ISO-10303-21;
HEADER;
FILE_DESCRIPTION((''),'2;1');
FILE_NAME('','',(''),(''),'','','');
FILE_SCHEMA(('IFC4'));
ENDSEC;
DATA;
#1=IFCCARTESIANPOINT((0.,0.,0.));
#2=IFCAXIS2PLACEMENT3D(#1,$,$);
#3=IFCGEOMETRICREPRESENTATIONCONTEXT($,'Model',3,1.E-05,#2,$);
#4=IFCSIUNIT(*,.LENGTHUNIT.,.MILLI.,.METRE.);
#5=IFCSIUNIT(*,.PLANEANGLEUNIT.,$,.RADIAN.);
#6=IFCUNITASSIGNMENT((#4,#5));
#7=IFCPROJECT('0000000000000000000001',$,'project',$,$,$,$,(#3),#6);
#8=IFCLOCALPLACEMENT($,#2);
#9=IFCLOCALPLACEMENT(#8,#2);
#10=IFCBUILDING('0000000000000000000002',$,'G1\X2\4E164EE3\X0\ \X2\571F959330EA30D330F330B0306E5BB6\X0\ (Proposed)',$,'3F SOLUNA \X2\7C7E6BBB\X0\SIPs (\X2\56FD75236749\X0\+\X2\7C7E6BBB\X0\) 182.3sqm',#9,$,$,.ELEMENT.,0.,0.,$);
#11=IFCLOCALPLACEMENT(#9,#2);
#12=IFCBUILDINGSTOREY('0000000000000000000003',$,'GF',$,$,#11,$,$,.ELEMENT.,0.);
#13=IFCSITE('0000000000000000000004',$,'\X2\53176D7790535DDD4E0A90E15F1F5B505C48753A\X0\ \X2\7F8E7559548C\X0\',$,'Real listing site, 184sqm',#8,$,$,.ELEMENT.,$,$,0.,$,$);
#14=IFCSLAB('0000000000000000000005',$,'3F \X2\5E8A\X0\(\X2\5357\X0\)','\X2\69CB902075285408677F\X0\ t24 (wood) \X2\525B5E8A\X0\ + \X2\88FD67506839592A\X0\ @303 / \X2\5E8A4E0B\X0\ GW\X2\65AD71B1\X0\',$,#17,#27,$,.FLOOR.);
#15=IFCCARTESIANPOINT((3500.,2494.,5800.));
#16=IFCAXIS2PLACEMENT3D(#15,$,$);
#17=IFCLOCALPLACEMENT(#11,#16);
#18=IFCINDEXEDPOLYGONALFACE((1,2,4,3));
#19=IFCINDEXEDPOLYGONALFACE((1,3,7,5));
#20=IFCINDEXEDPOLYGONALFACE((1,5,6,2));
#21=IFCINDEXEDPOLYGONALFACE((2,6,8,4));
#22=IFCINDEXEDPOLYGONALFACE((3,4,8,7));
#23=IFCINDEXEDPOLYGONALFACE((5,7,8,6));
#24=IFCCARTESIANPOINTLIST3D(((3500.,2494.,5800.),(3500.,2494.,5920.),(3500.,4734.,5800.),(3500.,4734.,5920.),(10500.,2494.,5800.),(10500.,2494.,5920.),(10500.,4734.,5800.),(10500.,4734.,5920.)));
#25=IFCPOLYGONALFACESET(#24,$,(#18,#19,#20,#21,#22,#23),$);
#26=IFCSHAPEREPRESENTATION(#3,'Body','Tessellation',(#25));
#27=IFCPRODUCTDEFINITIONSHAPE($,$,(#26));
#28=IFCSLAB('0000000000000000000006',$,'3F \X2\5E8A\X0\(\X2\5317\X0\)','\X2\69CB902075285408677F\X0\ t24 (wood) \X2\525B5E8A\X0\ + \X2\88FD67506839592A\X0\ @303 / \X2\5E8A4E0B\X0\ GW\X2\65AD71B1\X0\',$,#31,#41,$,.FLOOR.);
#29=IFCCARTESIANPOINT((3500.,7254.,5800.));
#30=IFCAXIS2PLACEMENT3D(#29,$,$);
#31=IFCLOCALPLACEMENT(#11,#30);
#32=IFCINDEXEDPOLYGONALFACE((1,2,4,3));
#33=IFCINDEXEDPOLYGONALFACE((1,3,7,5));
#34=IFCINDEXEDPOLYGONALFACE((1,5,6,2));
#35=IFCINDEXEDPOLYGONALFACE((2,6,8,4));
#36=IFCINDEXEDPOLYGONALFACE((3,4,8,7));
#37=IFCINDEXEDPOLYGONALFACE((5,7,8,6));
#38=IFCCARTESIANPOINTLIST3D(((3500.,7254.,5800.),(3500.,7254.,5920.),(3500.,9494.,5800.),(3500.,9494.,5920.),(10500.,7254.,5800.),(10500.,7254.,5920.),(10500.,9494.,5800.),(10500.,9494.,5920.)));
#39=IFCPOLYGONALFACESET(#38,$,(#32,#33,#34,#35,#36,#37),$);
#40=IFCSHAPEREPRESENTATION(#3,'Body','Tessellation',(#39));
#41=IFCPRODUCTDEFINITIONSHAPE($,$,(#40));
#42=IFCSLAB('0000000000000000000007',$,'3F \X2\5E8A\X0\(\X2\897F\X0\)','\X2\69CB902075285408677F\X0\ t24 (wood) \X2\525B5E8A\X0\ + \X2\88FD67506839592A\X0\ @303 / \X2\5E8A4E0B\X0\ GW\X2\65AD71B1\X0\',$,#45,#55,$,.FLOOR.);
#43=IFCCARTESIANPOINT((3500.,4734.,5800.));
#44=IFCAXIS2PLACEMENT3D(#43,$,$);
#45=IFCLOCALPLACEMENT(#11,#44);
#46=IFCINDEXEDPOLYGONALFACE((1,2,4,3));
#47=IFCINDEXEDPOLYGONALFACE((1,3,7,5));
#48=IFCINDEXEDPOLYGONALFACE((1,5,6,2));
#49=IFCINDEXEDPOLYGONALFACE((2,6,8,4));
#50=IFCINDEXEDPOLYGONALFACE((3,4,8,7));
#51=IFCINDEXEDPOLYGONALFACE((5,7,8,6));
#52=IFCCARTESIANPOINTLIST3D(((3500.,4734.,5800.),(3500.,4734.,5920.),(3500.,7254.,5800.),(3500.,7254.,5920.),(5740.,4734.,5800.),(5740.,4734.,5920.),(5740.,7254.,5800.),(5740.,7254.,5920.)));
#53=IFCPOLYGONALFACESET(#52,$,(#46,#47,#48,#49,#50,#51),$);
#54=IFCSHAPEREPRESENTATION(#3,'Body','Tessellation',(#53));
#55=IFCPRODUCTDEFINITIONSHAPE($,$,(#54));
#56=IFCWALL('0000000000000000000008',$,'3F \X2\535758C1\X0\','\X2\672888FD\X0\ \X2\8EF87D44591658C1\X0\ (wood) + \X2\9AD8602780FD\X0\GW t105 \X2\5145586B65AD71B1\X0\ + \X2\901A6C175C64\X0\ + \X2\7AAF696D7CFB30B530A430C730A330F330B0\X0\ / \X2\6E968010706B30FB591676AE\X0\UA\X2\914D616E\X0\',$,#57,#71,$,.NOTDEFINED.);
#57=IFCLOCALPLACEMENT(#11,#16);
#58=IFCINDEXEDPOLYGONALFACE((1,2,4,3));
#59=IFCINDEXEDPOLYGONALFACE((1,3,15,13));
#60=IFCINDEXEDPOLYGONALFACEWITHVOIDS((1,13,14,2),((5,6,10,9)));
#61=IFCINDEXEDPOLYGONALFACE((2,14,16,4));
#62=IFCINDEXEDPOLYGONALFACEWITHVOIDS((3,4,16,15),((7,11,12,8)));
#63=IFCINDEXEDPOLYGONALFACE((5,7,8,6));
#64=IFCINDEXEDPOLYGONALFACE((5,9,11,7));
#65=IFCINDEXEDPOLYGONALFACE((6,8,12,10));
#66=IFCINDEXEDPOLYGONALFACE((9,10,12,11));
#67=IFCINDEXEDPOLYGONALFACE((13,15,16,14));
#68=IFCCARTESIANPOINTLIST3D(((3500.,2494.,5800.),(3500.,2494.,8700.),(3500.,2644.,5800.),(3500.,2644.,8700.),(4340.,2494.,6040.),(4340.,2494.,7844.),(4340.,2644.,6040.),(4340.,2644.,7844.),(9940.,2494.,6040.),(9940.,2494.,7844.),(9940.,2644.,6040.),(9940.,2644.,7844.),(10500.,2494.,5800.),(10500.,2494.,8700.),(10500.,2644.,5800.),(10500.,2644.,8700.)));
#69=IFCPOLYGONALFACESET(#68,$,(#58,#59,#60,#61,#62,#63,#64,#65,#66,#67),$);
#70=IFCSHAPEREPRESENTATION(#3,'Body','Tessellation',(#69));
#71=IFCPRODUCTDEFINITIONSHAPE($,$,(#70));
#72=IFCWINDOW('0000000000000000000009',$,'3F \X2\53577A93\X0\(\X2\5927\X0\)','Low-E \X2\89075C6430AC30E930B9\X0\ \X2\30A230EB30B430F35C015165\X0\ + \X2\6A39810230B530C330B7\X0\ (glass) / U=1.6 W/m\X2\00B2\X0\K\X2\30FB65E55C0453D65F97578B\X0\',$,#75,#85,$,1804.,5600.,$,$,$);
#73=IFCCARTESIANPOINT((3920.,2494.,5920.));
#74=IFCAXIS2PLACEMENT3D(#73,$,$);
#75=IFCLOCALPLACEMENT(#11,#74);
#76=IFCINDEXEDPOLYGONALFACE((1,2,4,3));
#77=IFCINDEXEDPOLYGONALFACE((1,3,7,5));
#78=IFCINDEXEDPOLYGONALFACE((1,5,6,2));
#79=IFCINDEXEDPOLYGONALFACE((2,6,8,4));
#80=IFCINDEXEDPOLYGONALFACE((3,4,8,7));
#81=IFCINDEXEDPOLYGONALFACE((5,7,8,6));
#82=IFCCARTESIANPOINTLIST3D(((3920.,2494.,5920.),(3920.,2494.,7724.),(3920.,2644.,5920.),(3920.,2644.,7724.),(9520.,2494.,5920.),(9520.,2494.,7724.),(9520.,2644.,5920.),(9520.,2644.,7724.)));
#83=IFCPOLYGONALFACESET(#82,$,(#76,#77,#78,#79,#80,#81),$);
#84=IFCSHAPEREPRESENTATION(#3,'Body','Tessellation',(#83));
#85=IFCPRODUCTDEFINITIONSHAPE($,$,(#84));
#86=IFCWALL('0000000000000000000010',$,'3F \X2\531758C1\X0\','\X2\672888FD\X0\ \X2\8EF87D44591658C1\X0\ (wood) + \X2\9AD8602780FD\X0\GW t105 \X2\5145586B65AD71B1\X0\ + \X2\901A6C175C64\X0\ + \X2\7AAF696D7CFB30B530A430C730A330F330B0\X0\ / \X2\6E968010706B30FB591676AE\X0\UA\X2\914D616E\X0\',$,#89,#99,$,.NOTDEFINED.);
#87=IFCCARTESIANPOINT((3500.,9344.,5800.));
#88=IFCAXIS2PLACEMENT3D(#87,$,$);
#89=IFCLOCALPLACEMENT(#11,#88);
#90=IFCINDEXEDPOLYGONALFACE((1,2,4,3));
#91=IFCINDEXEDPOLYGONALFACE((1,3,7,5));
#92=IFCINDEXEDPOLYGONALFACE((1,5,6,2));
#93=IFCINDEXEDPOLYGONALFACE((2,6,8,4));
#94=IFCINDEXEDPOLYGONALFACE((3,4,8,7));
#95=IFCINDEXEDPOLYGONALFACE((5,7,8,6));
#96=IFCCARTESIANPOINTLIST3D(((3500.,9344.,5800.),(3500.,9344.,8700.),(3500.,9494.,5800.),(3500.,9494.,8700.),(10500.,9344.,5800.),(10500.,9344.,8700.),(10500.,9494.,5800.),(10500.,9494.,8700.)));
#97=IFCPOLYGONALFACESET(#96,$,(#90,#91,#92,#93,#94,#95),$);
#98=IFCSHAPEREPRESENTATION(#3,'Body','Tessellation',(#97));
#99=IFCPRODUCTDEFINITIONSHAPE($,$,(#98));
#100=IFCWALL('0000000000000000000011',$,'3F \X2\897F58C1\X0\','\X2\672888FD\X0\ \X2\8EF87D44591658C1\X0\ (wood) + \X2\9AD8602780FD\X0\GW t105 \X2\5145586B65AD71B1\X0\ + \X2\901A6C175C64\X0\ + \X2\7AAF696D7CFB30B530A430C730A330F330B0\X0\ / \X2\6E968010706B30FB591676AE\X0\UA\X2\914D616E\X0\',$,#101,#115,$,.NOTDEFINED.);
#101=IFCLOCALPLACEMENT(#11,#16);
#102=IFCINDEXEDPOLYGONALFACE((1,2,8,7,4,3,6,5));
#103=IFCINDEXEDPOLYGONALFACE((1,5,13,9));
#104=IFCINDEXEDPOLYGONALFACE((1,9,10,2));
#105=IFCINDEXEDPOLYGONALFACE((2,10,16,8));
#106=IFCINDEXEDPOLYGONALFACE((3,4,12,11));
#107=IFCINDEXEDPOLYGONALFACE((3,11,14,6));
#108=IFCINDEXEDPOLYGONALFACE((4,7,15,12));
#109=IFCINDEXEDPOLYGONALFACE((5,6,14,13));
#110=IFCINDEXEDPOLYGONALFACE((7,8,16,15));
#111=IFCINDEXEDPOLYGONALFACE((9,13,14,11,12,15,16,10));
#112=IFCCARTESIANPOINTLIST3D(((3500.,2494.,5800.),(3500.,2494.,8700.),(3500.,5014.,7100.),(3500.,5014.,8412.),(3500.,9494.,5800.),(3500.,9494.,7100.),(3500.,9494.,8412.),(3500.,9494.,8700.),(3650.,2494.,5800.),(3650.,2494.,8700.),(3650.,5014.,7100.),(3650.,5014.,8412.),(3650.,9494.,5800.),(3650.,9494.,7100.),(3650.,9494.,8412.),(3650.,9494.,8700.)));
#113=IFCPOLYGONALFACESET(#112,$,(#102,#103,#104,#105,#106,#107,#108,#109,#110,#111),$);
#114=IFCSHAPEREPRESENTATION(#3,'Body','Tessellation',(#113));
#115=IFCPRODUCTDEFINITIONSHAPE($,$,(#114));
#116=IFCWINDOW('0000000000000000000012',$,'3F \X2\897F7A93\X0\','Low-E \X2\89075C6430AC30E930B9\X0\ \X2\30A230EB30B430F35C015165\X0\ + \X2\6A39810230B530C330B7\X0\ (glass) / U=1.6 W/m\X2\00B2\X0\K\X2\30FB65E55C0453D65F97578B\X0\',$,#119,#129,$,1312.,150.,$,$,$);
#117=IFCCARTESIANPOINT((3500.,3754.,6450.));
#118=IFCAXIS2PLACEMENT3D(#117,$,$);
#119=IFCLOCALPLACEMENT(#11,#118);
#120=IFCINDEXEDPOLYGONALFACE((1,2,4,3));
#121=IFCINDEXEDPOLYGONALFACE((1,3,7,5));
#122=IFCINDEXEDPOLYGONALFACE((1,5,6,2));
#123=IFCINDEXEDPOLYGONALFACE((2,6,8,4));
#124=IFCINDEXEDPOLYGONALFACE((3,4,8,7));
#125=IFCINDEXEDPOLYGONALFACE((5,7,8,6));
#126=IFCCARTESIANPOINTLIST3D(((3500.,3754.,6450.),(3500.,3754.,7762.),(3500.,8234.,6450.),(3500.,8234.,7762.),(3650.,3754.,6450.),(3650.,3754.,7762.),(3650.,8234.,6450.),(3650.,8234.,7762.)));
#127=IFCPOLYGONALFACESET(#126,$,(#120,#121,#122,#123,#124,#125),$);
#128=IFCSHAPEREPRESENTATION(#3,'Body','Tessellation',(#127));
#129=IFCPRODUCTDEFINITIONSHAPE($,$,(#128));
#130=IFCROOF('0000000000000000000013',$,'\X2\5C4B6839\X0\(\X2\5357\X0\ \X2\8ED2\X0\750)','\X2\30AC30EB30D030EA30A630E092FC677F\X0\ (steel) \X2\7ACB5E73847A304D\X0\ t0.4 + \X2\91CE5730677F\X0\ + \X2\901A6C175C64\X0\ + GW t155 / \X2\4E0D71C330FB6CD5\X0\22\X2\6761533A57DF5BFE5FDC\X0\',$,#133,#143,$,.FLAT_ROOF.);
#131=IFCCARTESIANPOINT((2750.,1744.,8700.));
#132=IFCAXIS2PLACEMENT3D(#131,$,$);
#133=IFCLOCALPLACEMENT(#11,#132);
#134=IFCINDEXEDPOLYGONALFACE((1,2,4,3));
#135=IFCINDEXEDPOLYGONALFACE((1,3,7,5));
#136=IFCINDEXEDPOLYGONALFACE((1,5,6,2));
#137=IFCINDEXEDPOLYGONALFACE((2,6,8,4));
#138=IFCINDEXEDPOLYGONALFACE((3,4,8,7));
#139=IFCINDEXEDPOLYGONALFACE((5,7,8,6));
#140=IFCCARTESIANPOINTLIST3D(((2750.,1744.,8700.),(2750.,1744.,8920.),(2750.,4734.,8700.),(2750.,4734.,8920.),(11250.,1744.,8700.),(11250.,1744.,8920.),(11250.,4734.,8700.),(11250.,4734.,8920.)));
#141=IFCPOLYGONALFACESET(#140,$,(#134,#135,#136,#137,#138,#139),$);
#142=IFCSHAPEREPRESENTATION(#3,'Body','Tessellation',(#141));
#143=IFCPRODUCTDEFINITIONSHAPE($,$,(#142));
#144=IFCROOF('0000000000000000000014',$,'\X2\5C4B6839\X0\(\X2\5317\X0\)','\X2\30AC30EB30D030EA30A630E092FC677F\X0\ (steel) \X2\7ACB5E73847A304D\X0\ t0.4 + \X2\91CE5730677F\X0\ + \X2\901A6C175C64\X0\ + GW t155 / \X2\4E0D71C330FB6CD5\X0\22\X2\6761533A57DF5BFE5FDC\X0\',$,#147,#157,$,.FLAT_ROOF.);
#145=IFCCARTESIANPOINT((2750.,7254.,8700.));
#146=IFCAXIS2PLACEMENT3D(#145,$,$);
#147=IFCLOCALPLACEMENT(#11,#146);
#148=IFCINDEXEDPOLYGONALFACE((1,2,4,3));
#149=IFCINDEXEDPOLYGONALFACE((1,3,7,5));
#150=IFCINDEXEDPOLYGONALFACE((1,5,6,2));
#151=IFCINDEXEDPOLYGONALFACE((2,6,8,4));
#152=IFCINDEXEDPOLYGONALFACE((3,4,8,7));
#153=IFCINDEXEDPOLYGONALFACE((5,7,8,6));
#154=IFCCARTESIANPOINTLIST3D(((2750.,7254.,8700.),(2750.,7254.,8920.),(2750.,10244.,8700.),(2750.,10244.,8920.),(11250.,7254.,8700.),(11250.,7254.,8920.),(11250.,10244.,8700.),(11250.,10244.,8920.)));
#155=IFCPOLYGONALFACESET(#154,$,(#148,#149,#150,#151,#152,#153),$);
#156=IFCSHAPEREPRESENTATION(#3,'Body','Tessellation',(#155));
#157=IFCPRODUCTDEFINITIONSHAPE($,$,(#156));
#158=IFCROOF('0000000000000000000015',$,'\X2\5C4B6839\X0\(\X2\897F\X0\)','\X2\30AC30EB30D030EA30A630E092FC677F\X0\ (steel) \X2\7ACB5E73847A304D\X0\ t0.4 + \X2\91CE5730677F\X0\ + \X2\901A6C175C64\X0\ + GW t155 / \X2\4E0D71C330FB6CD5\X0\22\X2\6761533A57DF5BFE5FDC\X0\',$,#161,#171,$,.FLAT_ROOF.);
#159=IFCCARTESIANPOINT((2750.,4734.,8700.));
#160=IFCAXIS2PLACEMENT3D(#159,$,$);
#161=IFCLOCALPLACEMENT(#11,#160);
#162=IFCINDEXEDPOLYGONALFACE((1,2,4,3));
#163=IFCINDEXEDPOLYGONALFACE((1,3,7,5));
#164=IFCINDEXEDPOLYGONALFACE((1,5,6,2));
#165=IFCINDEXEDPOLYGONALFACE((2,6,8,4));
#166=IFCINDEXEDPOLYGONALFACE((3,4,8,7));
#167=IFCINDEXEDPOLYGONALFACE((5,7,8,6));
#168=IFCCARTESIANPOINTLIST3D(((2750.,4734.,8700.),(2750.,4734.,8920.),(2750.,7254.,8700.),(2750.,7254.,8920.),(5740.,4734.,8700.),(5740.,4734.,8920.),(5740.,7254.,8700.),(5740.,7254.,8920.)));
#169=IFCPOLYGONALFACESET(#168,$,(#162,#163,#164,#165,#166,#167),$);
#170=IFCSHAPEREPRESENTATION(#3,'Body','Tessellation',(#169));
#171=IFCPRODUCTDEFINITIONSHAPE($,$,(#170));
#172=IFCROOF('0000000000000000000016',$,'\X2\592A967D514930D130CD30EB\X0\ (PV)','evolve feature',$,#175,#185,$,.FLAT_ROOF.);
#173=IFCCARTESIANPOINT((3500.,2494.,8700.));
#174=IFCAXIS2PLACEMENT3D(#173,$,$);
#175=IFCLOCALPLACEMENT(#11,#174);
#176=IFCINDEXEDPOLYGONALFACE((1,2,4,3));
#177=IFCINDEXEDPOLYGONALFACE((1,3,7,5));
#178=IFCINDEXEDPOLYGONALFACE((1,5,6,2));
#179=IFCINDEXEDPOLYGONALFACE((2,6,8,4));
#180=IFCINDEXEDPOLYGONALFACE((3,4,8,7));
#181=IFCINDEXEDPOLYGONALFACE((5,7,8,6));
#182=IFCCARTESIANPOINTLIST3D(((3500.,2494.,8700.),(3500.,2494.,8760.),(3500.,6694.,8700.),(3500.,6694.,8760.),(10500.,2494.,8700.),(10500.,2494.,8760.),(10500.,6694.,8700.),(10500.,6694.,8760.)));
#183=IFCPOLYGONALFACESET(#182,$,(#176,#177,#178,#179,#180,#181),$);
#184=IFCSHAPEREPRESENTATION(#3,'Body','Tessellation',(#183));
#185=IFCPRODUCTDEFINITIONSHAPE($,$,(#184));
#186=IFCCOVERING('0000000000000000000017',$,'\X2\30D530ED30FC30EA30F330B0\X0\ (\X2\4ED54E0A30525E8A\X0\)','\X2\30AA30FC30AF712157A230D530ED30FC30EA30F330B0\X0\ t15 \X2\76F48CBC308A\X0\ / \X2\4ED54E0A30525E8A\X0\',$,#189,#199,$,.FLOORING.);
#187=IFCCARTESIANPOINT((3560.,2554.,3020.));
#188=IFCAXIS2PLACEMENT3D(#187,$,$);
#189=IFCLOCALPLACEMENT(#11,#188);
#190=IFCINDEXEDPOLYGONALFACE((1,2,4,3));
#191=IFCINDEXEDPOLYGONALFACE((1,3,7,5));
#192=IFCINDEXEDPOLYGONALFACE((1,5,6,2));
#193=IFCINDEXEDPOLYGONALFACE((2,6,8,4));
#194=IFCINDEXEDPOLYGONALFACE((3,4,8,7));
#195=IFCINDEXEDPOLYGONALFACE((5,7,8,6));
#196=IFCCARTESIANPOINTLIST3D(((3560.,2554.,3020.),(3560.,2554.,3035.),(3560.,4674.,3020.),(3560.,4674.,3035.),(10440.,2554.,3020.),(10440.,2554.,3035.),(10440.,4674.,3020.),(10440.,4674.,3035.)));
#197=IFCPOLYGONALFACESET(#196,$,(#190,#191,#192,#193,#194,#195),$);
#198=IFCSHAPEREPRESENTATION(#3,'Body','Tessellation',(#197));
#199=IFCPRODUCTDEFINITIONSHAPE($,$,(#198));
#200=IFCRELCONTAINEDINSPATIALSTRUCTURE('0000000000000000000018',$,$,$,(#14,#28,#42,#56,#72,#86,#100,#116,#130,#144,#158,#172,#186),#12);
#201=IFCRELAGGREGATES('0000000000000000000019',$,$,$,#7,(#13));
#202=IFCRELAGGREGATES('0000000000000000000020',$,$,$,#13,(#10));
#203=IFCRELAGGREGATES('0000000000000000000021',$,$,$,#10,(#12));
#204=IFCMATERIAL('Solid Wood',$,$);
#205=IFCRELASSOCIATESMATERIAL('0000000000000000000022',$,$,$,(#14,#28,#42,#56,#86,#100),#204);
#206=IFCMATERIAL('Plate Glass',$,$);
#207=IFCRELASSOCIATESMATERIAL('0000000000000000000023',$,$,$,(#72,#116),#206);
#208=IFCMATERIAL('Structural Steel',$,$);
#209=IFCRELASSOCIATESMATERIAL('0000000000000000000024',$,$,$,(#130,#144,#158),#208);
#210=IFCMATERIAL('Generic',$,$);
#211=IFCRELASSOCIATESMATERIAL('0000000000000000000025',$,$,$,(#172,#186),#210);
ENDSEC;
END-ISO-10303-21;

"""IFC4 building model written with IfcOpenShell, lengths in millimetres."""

from ifc_helpers import new_model, si_unit, frame, frame_2d, origin, place, context, project, spatial, rectangle, extrude, material, element, fill, save


model = new_model("IFC4")

# Units and contexts
model_context = context("Model", 3, precision=1e-05, world=origin())
ifc_project = project(units=[si_unit("LENGTHUNIT", "METRE", prefix="MILLI"), si_unit("PLANEANGLEUNIT", "RADIAN")], contexts=[model_context])

# Site, building, storey
site_placement = place(None, origin())
site = spatial("IfcSite", under=ifc_project, at=site_placement, Name="北海道川上郡弟子屈町 美留和", ObjectType="Real listing site, 184sqm", CompositionType="ELEMENT", RefElevation=0.0)
building_placement = place(site_placement, origin())
building = spatial("IfcBuilding", under=site, at=building_placement, Name="G1世代 土間リビングの家 (Proposed)", ObjectType="3F SOLUNA 籾殻SIPs (国産杉+籾殻) 182.3sqm", CompositionType="ELEMENT", ElevationOfRefHeight=0.0, ElevationOfTerrain=0.0)
storey_placement = place(building_placement, origin())
storey = spatial("IfcBuildingStorey", under=building, at=storey_placement, Name="GF", CompositionType="ELEMENT", Elevation=0.0)

# Slabs
ifc_material_1 = material(Name="Solid Wood")
slab_1_placement = place(storey_placement, frame((3500.0, 2494.0, 5800.0)))
element("IfcSlab", 1, at=slab_1_placement, inside=storey, material=ifc_material_1, Name="3F 床(南)", Description="構造用合板 t24 (wood) 剛床 + 製材根太 @303 / 床下 GW断熱", PredefinedType="FLOOR", context=model_context, shape_type="SweptSolid", body=[
    extrude(rectangle(XDim=7000.0, YDim=2240.0, at=frame_2d((3500.0, 1120.0))), frame((3500.0, 2494.0, 5800.0)), (0.0, 0.0, 1.0), 120.0),
])
slab_2_placement = place(storey_placement, frame((3500.0, 7254.0, 5800.0)))
element("IfcSlab", 2, at=slab_2_placement, inside=storey, material=ifc_material_1, Name="3F 床(北)", Description="構造用合板 t24 (wood) 剛床 + 製材根太 @303 / 床下 GW断熱", PredefinedType="FLOOR", context=model_context, shape_type="SweptSolid", body=[
    extrude(rectangle(XDim=7000.0, YDim=2240.0, at=frame_2d((3500.0, 1120.0))), frame((3500.0, 7254.0, 5800.0)), (0.0, 0.0, 1.0), 120.0),
])
slab_3_placement = place(storey_placement, frame((3500.0, 4734.0, 5800.0)))
element("IfcSlab", 3, at=slab_3_placement, inside=storey, material=ifc_material_1, Name="3F 床(西)", Description="構造用合板 t24 (wood) 剛床 + 製材根太 @303 / 床下 GW断熱", PredefinedType="FLOOR", context=model_context, shape_type="SweptSolid", body=[
    extrude(rectangle(XDim=2240.0, YDim=2520.0, at=frame_2d((1120.0, 1260.0))), frame((3500.0, 4734.0, 5800.0)), (0.0, 0.0, 1.0), 120.0),
])

# Wall, opening, window
wall_1_placement = place(storey_placement, frame((3500.0, 2494.0, 5800.0)))
wall_1 = element("IfcWall", 4, at=wall_1_placement, inside=storey, material=ifc_material_1, Name="3F 南壁", Description="木製 軸組外壁 (wood) + 高性能GW t105 充填断熱 + 通気層 + 窯業系サイディング / 準耐火・外皮UA配慮", PredefinedType="NOTDEFINED", context=model_context, shape_type="SweptSolid", body=[
    extrude(rectangle(XDim=7000.0, YDim=150.0, at=frame_2d((3500.0, 75.0))), frame((3500.0, 2494.0, 5800.0)), (0.0, 0.0, 1.0), 2900.0),
])
opening_1_placement = place(storey_placement, frame((3920.0, 2494.0, 5920.0)))
opening_1 = element("IfcOpeningElement", 5, at=opening_1_placement, cuts=wall_1, PredefinedType="NOTDEFINED", context=model_context, shape_type="SweptSolid", body=[
    extrude(rectangle(XDim=5600.0, YDim=150.0, at=frame_2d((2800.0, 75.0))), frame((3920.0, 2494.0, 5920.0)), (0.0, 0.0, 1.0), 1804.0),
])
ifc_material_2 = material(Name="Plate Glass")
window_1_placement = place(storey_placement, frame((3920.0, 2494.0, 5920.0)))
window_1 = element("IfcWindow", 6, at=window_1_placement, inside=storey, material=ifc_material_2, Name="3F 南窓(大)", Description="Low-E 複層ガラス アルゴン封入 + 樹脂サッシ (glass) / U=1.6 W/m²K・日射取得型", OverallHeight=1804.0, OverallWidth=5600.0, context=model_context, shape_type="SweptSolid", body=[
    extrude(rectangle(XDim=5600.0, YDim=150.0, at=frame_2d((2800.0, 75.0))), frame((3920.0, 2494.0, 5920.0)), (0.0, 0.0, 1.0), 1804.0),
])
fill(opening_1, window_1)

# Wall
wall_2_placement = place(storey_placement, frame((3500.0, 9344.0, 5800.0)))
element("IfcWall", 7, at=wall_2_placement, inside=storey, material=ifc_material_1, Name="3F 北壁", Description="木製 軸組外壁 (wood) + 高性能GW t105 充填断熱 + 通気層 + 窯業系サイディング / 準耐火・外皮UA配慮", PredefinedType="NOTDEFINED", context=model_context, shape_type="SweptSolid", body=[
    extrude(rectangle(XDim=7000.0, YDim=150.0, at=frame_2d((3500.0, 75.0))), frame((3500.0, 9344.0, 5800.0)), (0.0, 0.0, 1.0), 2900.0),
])

# Wall, opening, window
wall_3_placement = place(storey_placement, frame((3500.0, 2494.0, 5800.0)))
wall_3 = element("IfcWall", 8, at=wall_3_placement, inside=storey, material=ifc_material_1, Name="3F 西壁", Description="木製 軸組外壁 (wood) + 高性能GW t105 充填断熱 + 通気層 + 窯業系サイディング / 準耐火・外皮UA配慮", PredefinedType="NOTDEFINED", context=model_context, shape_type="SweptSolid", body=[
    extrude(rectangle(XDim=150.0, YDim=7000.0, at=frame_2d((75.0, 3500.0))), frame((3500.0, 2494.0, 5800.0)), (0.0, 0.0, 1.0), 2900.0),
])
opening_2_placement = place(storey_placement, frame((3500.0, 3754.0, 6450.0)))
opening_2 = element("IfcOpeningElement", 9, at=opening_2_placement, cuts=wall_3, PredefinedType="NOTDEFINED", context=model_context, shape_type="SweptSolid", body=[
    extrude(rectangle(XDim=150.0, YDim=4480.0, at=frame_2d((75.0, 2240.0))), frame((3500.0, 3754.0, 6450.0)), (0.0, 0.0, 1.0), 1312.0),
])
window_2_placement = place(storey_placement, frame((3500.0, 3754.0, 6450.0)))
window_2 = element("IfcWindow", 10, at=window_2_placement, inside=storey, material=ifc_material_2, Name="3F 西窓", Description="Low-E 複層ガラス アルゴン封入 + 樹脂サッシ (glass) / U=1.6 W/m²K・日射取得型", OverallHeight=1312.0, OverallWidth=150.0, context=model_context, shape_type="SweptSolid", body=[
    extrude(rectangle(XDim=150.0, YDim=4480.0, at=frame_2d((75.0, 2240.0))), frame((3500.0, 3754.0, 6450.0)), (0.0, 0.0, 1.0), 1312.0),
])
fill(opening_2, window_2)

# Roofs
ifc_material_3 = material(Name="Structural Steel")
roof_1_placement = place(storey_placement, frame((2750.0, 1744.0, 8700.0)))
element("IfcRoof", 11, at=roof_1_placement, inside=storey, material=ifc_material_3, Name="屋根(南 軒750)", Description="ガルバリウム鋼板 (steel) 立平葺き t0.4 + 野地板 + 通気層 + GW t155 / 不燃・法22条区域対応", PredefinedType="FLAT_ROOF", context=model_context, shape_type="SweptSolid", body=[
    extrude(rectangle(XDim=8500.0, YDim=2990.0, at=frame_2d((4250.0, 1495.0))), frame((2750.0, 1744.0, 8700.0)), (0.0, 0.0, 1.0), 220.0),
])
roof_2_placement = place(storey_placement, frame((2750.0, 7254.0, 8700.0)))
element("IfcRoof", 12, at=roof_2_placement, inside=storey, material=ifc_material_3, Name="屋根(北)", Description="ガルバリウム鋼板 (steel) 立平葺き t0.4 + 野地板 + 通気層 + GW t155 / 不燃・法22条区域対応", PredefinedType="FLAT_ROOF", context=model_context, shape_type="SweptSolid", body=[
    extrude(rectangle(XDim=8500.0, YDim=2990.0, at=frame_2d((4250.0, 1495.0))), frame((2750.0, 7254.0, 8700.0)), (0.0, 0.0, 1.0), 220.0),
])
roof_3_placement = place(storey_placement, frame((2750.0, 4734.0, 8700.0)))
element("IfcRoof", 13, at=roof_3_placement, inside=storey, material=ifc_material_3, Name="屋根(西)", Description="ガルバリウム鋼板 (steel) 立平葺き t0.4 + 野地板 + 通気層 + GW t155 / 不燃・法22条区域対応", PredefinedType="FLAT_ROOF", context=model_context, shape_type="SweptSolid", body=[
    extrude(rectangle(XDim=2990.0, YDim=2520.0, at=frame_2d((1495.0, 1260.0))), frame((2750.0, 4734.0, 8700.0)), (0.0, 0.0, 1.0), 220.0),
])
ifc_material_4 = material(Name="Generic")
roof_4_placement = place(storey_placement, frame((3500.0, 2494.0, 8700.0)))
element("IfcRoof", 14, at=roof_4_placement, inside=storey, material=ifc_material_4, Name="太陽光パネル (PV)", Description="evolve feature", PredefinedType="FLAT_ROOF", context=model_context, shape_type="SweptSolid", body=[
    extrude(rectangle(XDim=7000.0, YDim=4200.0, at=frame_2d((3500.0, 2100.0))), frame((3500.0, 2494.0, 8700.0)), (0.0, 0.0, 1.0), 60.0),
])

# Covering
covering_1_placement = place(storey_placement, frame((3560.0, 2554.0, 3020.0)))
element("IfcCovering", 15, at=covering_1_placement, inside=storey, material=ifc_material_4, Name="フローリング (仕上げ床)", Description="オーク無垢フローリング t15 直貼り / 仕上げ床", PredefinedType="FLOORING", context=model_context, shape_type="SweptSolid", body=[
    extrude(rectangle(XDim=6880.0, YDim=2120.0, at=frame_2d((3440.0, 1060.0))), frame((3560.0, 2554.0, 3020.0)), (0.0, 0.0, 1.0), 15.0),
])

save(model, "model.ifc")
